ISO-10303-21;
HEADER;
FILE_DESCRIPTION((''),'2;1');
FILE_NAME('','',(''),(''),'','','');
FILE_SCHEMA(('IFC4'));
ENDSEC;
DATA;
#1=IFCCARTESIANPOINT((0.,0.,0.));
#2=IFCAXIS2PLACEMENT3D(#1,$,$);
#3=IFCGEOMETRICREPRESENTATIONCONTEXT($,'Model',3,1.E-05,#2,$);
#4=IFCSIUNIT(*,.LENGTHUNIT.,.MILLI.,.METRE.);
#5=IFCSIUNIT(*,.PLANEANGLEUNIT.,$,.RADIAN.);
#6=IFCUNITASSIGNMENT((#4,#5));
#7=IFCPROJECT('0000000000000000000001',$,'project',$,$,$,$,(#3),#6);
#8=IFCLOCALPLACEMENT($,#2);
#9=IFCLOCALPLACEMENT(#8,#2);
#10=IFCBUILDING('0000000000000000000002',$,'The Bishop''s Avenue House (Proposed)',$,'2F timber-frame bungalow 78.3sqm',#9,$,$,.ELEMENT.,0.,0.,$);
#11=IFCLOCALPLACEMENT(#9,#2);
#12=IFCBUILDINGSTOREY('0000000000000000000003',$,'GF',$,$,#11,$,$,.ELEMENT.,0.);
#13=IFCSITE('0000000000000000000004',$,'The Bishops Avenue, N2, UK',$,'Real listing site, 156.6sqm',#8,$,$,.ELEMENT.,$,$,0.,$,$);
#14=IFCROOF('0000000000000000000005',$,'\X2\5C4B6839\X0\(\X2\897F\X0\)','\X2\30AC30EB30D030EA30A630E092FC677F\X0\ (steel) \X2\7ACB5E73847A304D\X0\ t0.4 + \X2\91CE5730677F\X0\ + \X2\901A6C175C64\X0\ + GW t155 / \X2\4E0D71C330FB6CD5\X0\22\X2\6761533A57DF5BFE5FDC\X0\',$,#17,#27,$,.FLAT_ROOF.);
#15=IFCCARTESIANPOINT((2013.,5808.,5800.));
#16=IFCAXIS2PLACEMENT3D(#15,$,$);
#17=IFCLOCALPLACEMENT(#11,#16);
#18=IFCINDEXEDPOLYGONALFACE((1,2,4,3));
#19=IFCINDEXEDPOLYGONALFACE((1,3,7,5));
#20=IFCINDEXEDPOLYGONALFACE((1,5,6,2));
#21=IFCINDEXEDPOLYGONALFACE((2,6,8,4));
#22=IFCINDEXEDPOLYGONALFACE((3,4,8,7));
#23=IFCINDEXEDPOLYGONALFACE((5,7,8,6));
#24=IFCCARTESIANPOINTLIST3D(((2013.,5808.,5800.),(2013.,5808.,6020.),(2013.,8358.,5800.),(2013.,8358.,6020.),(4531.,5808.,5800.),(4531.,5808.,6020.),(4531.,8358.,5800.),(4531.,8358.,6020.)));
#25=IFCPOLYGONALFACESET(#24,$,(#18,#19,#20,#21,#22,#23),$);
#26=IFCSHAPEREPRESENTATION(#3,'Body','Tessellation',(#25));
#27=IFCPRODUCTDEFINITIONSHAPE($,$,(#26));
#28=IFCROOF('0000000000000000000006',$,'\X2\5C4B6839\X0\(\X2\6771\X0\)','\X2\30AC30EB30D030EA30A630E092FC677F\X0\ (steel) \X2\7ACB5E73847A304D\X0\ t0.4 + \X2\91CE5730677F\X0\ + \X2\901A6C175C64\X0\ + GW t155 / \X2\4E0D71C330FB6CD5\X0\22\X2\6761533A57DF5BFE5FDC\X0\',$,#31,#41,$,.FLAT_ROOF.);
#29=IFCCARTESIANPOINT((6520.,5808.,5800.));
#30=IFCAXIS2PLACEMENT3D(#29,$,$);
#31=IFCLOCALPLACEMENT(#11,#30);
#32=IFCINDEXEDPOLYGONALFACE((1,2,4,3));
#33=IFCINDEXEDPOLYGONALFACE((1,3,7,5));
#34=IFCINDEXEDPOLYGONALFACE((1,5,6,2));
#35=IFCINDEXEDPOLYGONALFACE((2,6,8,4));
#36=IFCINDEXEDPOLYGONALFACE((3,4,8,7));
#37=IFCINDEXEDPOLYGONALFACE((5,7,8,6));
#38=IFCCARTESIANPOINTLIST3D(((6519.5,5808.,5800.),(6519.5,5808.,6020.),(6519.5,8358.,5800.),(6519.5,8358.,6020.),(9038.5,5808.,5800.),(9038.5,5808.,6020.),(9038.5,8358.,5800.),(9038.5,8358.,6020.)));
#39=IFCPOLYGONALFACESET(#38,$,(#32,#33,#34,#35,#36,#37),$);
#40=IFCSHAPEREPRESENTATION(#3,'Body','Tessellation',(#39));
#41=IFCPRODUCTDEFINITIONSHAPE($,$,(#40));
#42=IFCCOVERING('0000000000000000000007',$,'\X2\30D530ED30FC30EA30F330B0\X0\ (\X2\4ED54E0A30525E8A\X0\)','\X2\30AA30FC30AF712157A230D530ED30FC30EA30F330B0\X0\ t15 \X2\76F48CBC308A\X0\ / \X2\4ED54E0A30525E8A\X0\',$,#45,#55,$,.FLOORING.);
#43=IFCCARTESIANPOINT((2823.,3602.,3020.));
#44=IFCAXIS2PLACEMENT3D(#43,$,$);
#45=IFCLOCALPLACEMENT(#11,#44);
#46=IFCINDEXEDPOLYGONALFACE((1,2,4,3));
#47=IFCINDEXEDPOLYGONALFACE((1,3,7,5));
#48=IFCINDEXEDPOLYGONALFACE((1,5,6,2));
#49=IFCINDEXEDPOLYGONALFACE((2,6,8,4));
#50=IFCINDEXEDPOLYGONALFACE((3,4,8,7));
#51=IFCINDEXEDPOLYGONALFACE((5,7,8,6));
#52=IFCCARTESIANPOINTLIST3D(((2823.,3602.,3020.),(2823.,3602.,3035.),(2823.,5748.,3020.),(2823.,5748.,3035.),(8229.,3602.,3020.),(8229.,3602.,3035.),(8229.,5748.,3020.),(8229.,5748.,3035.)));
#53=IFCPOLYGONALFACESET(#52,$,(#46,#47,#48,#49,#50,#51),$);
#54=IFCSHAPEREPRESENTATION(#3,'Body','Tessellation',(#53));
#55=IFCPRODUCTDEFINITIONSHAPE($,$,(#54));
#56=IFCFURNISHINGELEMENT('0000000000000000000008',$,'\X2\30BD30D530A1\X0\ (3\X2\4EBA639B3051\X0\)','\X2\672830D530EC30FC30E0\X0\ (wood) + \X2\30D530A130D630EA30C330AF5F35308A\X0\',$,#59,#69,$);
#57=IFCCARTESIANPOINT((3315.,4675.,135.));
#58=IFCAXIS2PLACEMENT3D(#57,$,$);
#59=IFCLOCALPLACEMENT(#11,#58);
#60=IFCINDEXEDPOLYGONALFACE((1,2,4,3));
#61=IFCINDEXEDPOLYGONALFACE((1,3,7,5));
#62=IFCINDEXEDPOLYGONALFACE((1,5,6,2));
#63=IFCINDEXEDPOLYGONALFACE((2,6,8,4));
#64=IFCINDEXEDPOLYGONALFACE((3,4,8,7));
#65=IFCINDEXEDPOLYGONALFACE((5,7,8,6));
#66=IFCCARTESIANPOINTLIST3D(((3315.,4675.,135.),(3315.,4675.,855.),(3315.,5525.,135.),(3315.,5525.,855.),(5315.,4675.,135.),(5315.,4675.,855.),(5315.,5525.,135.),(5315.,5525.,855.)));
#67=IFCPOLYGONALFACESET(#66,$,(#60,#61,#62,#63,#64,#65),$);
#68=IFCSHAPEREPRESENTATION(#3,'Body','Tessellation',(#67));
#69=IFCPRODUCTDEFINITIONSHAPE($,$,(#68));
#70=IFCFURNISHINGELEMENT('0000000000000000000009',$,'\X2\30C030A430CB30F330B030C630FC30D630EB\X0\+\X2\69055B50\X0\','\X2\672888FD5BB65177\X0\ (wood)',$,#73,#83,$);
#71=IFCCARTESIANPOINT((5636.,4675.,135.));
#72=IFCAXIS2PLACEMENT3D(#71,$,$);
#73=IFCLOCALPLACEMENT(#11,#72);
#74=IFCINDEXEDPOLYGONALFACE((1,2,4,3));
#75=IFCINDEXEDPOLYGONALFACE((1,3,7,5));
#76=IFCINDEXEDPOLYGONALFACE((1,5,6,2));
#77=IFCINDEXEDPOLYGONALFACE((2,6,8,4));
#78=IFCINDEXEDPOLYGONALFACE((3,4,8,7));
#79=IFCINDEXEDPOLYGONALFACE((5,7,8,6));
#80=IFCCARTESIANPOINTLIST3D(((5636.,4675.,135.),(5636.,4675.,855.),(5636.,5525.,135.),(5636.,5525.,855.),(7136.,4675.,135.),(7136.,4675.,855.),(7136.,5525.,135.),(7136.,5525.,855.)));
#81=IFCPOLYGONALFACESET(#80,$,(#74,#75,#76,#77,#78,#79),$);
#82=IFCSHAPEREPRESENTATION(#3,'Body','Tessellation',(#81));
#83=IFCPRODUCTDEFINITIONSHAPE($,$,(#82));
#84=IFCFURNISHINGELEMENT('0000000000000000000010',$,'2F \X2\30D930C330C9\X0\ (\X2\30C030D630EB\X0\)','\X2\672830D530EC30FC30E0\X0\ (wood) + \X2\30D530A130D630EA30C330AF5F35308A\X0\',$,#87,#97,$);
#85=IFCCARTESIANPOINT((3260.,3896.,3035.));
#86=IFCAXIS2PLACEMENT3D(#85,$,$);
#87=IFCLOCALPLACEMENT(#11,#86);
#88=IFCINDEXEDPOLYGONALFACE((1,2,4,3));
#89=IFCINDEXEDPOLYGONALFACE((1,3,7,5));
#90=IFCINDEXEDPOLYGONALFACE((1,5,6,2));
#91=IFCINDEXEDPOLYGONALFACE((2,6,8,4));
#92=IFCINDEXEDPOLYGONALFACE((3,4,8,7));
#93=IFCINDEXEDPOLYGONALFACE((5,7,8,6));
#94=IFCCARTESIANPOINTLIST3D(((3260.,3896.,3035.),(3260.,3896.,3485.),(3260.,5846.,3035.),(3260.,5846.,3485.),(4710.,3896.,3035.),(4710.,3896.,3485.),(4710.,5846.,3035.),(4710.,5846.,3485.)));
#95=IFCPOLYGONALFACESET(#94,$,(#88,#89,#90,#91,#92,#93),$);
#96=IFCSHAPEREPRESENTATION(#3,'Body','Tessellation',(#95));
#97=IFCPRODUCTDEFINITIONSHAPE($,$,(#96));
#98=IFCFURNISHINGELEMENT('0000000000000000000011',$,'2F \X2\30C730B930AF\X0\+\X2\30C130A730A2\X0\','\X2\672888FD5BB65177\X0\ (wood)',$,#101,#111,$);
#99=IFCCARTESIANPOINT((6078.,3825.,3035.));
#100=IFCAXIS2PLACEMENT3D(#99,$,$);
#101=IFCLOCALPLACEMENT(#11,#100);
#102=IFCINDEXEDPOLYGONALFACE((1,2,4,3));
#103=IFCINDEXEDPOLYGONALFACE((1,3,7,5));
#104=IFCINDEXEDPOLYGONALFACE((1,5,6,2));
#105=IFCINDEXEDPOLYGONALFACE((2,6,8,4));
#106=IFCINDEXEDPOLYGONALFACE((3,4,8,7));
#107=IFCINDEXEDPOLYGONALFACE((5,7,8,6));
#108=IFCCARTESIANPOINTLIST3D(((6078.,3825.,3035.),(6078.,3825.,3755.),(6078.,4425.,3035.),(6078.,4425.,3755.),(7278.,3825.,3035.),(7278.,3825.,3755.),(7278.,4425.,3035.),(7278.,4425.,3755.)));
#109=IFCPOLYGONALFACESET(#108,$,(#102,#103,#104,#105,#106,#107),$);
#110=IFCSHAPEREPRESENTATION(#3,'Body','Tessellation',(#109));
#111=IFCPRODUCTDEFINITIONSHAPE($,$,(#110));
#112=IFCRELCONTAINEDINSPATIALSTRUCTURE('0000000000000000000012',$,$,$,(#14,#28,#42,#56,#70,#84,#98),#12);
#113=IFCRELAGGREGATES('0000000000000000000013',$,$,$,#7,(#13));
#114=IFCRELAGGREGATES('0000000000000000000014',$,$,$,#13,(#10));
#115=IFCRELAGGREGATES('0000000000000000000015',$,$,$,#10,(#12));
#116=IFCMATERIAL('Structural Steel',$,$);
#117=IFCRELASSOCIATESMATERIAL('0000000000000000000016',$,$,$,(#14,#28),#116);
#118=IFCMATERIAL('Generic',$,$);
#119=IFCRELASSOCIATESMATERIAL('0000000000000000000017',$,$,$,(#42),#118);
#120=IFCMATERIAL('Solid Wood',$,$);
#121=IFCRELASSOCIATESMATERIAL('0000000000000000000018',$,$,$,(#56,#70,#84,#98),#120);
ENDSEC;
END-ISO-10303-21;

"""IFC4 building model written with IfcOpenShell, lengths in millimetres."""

from ifc_helpers import new_model, si_unit, frame, frame_2d, origin, place, context, project, spatial, rectangle, extrude, material, element, save


model = new_model("IFC4")

# Units and contexts
model_context = context("Model", 3, precision=1e-05, world=origin())
ifc_project = project(units=[si_unit("LENGTHUNIT", "METRE", prefix="MILLI"), si_unit("PLANEANGLEUNIT", "RADIAN")], contexts=[model_context])

# Site, building, storey
site_placement = place(None, origin())
site = spatial("IfcSite", under=ifc_project, at=site_placement, Name="The Bishops Avenue, N2, UK", ObjectType="Real listing site, 156.6sqm", CompositionType="ELEMENT", RefElevation=0.0)
building_placement = place(site_placement, origin())
building = spatial("IfcBuilding", under=site, at=building_placement, Name="The Bishop's Avenue House (Proposed)", ObjectType="2F timber-frame bungalow 78.3sqm", CompositionType="ELEMENT", ElevationOfRefHeight=0.0, ElevationOfTerrain=0.0)
storey_placement = place(building_placement, origin())
storey = spatial("IfcBuildingStorey", under=building, at=storey_placement, Name="GF", CompositionType="ELEMENT", Elevation=0.0)

# Shared definitions
ifc_material_1 = material(Name="Solid Wood")

# Roofs
ifc_material_2 = material(Name="Structural Steel")
roof_1_placement = place(storey_placement, frame((2013.0, 5808.0, 5800.0)))
element("IfcRoof", 1, at=roof_1_placement, inside=storey, material=ifc_material_2, Name="屋根(西)", Description="ガルバリウム鋼板 (steel) 立平葺き t0.4 + 野地板 + 通気層 + GW t155 / 不燃・法22条区域対応", PredefinedType="FLAT_ROOF", context=model_context, shape_type="SweptSolid", body=[
    extrude(rectangle(XDim=2518.0, YDim=2550.0, at=frame_2d((1259.0, 1275.0))), frame((2013.0, 5808.0, 5800.0)), (0.0, 0.0, 1.0), 220.0),
])
roof_2_placement = place(storey_placement, frame((6520.0, 5808.0, 5800.0)))
element("IfcRoof", 2, at=roof_2_placement, inside=storey, material=ifc_material_2, Name="屋根(東)", Description="ガルバリウム鋼板 (steel) 立平葺き t0.4 + 野地板 + 通気層 + GW t155 / 不燃・法22条区域対応", PredefinedType="FLAT_ROOF", context=model_context, shape_type="SweptSolid", body=[
    extrude(rectangle(XDim=2519.0, YDim=2550.0, at=frame_2d((1259.0, 1275.0))), frame((6520.0, 5808.0, 5800.0)), (0.0, 0.0, 1.0), 220.0),
])

# Covering
ifc_material_3 = material(Name="Generic")
covering_placement = place(storey_placement, frame((2823.0, 3602.0, 3020.0)))
element("IfcCovering", 3, at=covering_placement, inside=storey, material=ifc_material_3, Name="フローリング (仕上げ床)", Description="オーク無垢フローリング t15 直貼り / 仕上げ床", PredefinedType="FLOORING", context=model_context, shape_type="SweptSolid", body=[
    extrude(rectangle(XDim=5406.0, YDim=2146.0, at=frame_2d((2703.0, 1073.0))), frame((2823.0, 3602.0, 3020.0)), (0.0, 0.0, 1.0), 15.0),
])

# Furnishing elements
furnishing_1_placement = place(storey_placement, frame((3315.0, 4675.0, 135.0)))
element("IfcFurnishingElement", 4, at=furnishing_1_placement, inside=storey, material=ifc_material_1, Name="ソファ (3人掛け)", Description="木フレーム (wood) + ファブリック張り", context=model_context, shape_type="SweptSolid", body=[
    extrude(rectangle(XDim=2000.0, YDim=850.0, at=frame_2d((1000.0, 425.0))), frame((3315.0, 4675.0, 135.0)), (0.0, 0.0, 1.0), 720.0),
])
furnishing_2_placement = place(storey_placement, frame((5636.0, 4675.0, 135.0)))
element("IfcFurnishingElement", 5, at=furnishing_2_placement, inside=storey, material=ifc_material_1, Name="ダイニングテーブル+椅子", Description="木製家具 (wood)", context=model_context, shape_type="SweptSolid", body=[
    extrude(rectangle(XDim=1500.0, YDim=850.0, at=frame_2d((750.0, 425.0))), frame((5636.0, 4675.0, 135.0)), (0.0, 0.0, 1.0), 720.0),
])
furnishing_3_placement = place(storey_placement, frame((3260.0, 3896.0, 3035.0)))
element("IfcFurnishingElement", 6, at=furnishing_3_placement, inside=storey, material=ifc_material_1, Name="2F ベッド (ダブル)", Description="木フレーム (wood) + ファブリック張り", context=model_context, shape_type="SweptSolid", body=[
    extrude(rectangle(XDim=1450.0, YDim=1950.0, at=frame_2d((725.0, 975.0))), frame((3260.0, 3896.0, 3035.0)), (0.0, 0.0, 1.0), 450.0),
])
furnishing_4_placement = place(storey_placement, frame((6078.0, 3825.0, 3035.0)))
element("IfcFurnishingElement", 7, at=furnishing_4_placement, inside=storey, material=ifc_material_1, Name="2F デスク+チェア", Description="木製家具 (wood)", context=model_context, shape_type="SweptSolid", body=[
    extrude(rectangle(XDim=1200.0, YDim=600.0, at=frame_2d((600.0, 300.0))), frame((6078.0, 3825.0, 3035.0)), (0.0, 0.0, 1.0), 720.0),
])

save(model, "model.ifc")
